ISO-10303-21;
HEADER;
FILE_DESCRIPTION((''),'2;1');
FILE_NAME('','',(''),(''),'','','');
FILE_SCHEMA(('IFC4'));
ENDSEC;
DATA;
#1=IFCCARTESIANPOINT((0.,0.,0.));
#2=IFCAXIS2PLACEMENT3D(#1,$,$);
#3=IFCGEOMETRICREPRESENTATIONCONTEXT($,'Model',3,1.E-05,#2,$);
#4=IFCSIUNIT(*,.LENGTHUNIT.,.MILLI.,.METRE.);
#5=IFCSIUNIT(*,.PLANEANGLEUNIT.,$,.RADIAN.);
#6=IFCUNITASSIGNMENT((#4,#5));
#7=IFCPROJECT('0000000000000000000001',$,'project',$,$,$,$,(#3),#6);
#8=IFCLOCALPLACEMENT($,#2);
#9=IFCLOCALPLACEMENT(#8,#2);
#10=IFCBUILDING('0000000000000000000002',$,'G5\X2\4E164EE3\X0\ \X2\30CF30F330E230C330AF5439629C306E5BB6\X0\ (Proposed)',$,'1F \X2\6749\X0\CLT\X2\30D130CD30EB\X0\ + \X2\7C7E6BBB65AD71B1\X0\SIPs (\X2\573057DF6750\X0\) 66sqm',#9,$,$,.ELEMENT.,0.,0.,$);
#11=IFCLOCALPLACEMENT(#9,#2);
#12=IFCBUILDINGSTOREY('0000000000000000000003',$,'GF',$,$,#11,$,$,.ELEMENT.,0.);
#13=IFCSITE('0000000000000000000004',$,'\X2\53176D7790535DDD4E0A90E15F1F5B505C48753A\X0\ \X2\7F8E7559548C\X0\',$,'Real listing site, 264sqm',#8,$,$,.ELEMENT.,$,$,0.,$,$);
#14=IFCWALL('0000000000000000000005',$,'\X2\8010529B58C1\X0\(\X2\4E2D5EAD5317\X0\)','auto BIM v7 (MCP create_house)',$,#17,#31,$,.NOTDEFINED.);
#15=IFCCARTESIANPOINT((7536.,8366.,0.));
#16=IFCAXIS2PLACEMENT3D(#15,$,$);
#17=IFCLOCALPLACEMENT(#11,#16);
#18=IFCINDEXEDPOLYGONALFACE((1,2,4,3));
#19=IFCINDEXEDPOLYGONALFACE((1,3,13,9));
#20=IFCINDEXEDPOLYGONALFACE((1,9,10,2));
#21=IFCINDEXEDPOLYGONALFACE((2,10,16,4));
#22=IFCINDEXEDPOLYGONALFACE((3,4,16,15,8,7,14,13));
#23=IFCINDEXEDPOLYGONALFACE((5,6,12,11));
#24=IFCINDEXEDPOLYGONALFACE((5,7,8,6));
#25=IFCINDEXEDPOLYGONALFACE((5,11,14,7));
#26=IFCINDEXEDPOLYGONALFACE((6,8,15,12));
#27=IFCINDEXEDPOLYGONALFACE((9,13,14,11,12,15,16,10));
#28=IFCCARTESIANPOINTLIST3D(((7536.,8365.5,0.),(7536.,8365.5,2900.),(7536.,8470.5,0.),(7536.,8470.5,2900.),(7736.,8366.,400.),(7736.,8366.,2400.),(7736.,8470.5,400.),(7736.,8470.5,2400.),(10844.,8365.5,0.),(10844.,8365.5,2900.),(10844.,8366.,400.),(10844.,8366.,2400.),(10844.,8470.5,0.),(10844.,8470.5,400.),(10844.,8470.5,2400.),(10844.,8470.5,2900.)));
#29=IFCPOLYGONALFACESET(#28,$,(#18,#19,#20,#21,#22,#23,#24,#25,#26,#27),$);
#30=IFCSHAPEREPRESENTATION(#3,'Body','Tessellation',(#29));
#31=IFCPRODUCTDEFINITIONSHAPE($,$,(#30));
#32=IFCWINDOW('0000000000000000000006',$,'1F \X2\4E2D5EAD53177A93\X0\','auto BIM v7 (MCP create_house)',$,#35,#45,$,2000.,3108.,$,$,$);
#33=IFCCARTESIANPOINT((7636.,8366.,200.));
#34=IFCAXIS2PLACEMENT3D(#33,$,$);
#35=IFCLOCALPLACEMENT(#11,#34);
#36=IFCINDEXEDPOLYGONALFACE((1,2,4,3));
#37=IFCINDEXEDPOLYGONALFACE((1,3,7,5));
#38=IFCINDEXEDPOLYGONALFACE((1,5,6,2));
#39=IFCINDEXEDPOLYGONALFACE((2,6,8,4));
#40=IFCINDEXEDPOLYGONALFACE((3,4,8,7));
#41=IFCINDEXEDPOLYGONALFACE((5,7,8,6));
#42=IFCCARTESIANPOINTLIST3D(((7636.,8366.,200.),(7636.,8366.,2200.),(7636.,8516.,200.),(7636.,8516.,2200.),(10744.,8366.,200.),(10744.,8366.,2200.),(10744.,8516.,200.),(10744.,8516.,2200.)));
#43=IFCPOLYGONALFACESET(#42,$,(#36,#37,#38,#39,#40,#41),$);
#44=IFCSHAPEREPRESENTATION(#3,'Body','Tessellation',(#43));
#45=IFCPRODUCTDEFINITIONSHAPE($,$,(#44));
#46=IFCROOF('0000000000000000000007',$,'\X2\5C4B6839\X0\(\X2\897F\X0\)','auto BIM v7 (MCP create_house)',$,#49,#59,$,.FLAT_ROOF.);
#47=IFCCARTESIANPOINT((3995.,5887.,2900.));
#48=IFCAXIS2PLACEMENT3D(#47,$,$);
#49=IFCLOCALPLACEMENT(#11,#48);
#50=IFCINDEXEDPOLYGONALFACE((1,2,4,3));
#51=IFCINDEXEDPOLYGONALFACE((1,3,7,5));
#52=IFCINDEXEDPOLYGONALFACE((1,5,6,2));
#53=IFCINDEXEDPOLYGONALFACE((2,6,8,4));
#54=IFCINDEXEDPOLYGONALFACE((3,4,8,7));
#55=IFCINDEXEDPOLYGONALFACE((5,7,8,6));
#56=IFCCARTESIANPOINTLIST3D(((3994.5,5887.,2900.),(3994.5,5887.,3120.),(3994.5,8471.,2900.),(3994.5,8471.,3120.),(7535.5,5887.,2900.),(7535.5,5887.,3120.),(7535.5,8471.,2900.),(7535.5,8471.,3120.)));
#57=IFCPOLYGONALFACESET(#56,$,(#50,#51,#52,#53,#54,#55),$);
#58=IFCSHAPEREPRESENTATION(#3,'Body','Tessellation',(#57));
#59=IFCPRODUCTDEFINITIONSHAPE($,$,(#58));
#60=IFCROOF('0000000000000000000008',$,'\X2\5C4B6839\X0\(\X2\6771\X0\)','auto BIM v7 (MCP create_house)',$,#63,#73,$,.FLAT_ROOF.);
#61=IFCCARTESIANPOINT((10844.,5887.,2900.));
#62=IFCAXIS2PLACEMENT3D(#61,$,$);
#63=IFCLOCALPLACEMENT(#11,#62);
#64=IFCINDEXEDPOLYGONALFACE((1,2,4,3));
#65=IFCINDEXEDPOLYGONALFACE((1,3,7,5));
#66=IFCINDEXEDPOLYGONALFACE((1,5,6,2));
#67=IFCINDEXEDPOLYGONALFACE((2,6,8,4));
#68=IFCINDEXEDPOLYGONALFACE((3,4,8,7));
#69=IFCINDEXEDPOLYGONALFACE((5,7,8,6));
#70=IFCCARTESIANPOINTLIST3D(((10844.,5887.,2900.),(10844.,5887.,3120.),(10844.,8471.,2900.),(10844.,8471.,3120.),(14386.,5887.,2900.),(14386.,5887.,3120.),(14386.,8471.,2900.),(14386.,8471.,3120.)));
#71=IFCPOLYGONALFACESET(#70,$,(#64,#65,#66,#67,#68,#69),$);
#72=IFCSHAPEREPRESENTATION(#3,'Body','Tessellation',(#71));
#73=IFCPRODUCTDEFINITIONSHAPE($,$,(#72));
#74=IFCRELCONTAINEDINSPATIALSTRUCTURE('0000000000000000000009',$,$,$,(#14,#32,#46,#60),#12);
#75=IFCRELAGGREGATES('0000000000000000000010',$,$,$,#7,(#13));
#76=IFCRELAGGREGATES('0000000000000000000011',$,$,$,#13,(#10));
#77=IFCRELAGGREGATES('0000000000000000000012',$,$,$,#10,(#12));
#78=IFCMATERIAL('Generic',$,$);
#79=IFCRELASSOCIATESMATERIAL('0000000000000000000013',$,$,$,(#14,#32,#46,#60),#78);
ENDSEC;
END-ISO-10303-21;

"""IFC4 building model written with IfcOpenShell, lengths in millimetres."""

from ifc_helpers import new_model, si_unit, frame, frame_2d, origin, place, context, project, spatial, rectangle, extrude, material, element, fill, save


model = new_model("IFC4")

# Units and contexts
model_context = context("Model", 3, precision=1e-05, world=origin())
ifc_project = project(units=[si_unit("LENGTHUNIT", "METRE", prefix="MILLI"), si_unit("PLANEANGLEUNIT", "RADIAN")], contexts=[model_context])

# Site, building, storey
site_placement = place(None, origin())
site = spatial("IfcSite", under=ifc_project, at=site_placement, Name="北海道川上郡弟子屈町 美留和", ObjectType="Real listing site, 264sqm", CompositionType="ELEMENT", RefElevation=0.0)
building_placement = place(site_placement, origin())
building = spatial("IfcBuilding", under=site, at=building_placement, Name="G5世代 ハンモック吹抜の家 (Proposed)", ObjectType="1F 杉CLTパネル + 籾殻断熱SIPs (地域材) 66sqm", CompositionType="ELEMENT", ElevationOfRefHeight=0.0, ElevationOfTerrain=0.0)
storey_placement = place(building_placement, origin())
storey = spatial("IfcBuildingStorey", under=building, at=storey_placement, Name="GF", CompositionType="ELEMENT", Elevation=0.0)

# Shared definitions
ifc_material = material(Name="Generic")

# Wall, opening, window
wall_1_placement = place(storey_placement, frame((7536.0, 8366.0, 0.0)))
wall_1 = element("IfcWall", 1, at=wall_1_placement, inside=storey, material=ifc_material, Name="耐力壁(中庭北)", Description="auto BIM v7 (MCP create_house)", PredefinedType="NOTDEFINED", context=model_context, shape_type="SweptSolid", body=[
    extrude(rectangle(XDim=3308.0, YDim=105.0, at=frame_2d((1654.0, 52.0))), frame((7536.0, 8366.0, 0.0)), (0.0, 0.0, 1.0), 2900.0),
])
opening_1_placement = place(storey_placement, frame((7636.0, 8366.0, 200.0)))
opening_1 = element("IfcOpeningElement", 2, at=opening_1_placement, cuts=wall_1, PredefinedType="NOTDEFINED", context=model_context, shape_type="SweptSolid", body=[
    extrude(rectangle(XDim=3108.0, YDim=150.0, at=frame_2d((1554.0, 75.0))), frame((7636.0, 8366.0, 200.0)), (0.0, 0.0, 1.0), 2000.0),
])
window_1_placement = place(storey_placement, frame((7636.0, 8366.0, 200.0)))
window_1 = element("IfcWindow", 3, at=window_1_placement, inside=storey, material=ifc_material, Name="1F 中庭北窓", Description="auto BIM v7 (MCP create_house)", OverallHeight=2000.0, OverallWidth=3108.0, context=model_context, shape_type="SweptSolid", body=[
    extrude(rectangle(XDim=3108.0, YDim=150.0, at=frame_2d((1554.0, 75.0))), frame((7636.0, 8366.0, 200.0)), (0.0, 0.0, 1.0), 2000.0),
])
fill(opening_1, window_1)

# Roofs
roof_1_placement = place(storey_placement, frame((3995.0, 5887.0, 2900.0)))
element("IfcRoof", 4, at=roof_1_placement, inside=storey, material=ifc_material, Name="屋根(西)", Description="auto BIM v7 (MCP create_house)", PredefinedType="FLAT_ROOF", context=model_context, shape_type="SweptSolid", body=[
    extrude(rectangle(XDim=3541.0, YDim=2584.0, at=frame_2d((1770.0, 1292.0))), frame((3995.0, 5887.0, 2900.0)), (0.0, 0.0, 1.0), 220.0),
])
roof_2_placement = place(storey_placement, frame((10844.0, 5887.0, 2900.0)))
element("IfcRoof", 5, at=roof_2_placement, inside=storey, material=ifc_material, Name="屋根(東)", Description="auto BIM v7 (MCP create_house)", PredefinedType="FLAT_ROOF", context=model_context, shape_type="SweptSolid", body=[
    extrude(rectangle(XDim=3542.0, YDim=2584.0, at=frame_2d((1771.0, 1292.0))), frame((10844.0, 5887.0, 2900.0)), (0.0, 0.0, 1.0), 220.0),
])

save(model, "model.ifc")
